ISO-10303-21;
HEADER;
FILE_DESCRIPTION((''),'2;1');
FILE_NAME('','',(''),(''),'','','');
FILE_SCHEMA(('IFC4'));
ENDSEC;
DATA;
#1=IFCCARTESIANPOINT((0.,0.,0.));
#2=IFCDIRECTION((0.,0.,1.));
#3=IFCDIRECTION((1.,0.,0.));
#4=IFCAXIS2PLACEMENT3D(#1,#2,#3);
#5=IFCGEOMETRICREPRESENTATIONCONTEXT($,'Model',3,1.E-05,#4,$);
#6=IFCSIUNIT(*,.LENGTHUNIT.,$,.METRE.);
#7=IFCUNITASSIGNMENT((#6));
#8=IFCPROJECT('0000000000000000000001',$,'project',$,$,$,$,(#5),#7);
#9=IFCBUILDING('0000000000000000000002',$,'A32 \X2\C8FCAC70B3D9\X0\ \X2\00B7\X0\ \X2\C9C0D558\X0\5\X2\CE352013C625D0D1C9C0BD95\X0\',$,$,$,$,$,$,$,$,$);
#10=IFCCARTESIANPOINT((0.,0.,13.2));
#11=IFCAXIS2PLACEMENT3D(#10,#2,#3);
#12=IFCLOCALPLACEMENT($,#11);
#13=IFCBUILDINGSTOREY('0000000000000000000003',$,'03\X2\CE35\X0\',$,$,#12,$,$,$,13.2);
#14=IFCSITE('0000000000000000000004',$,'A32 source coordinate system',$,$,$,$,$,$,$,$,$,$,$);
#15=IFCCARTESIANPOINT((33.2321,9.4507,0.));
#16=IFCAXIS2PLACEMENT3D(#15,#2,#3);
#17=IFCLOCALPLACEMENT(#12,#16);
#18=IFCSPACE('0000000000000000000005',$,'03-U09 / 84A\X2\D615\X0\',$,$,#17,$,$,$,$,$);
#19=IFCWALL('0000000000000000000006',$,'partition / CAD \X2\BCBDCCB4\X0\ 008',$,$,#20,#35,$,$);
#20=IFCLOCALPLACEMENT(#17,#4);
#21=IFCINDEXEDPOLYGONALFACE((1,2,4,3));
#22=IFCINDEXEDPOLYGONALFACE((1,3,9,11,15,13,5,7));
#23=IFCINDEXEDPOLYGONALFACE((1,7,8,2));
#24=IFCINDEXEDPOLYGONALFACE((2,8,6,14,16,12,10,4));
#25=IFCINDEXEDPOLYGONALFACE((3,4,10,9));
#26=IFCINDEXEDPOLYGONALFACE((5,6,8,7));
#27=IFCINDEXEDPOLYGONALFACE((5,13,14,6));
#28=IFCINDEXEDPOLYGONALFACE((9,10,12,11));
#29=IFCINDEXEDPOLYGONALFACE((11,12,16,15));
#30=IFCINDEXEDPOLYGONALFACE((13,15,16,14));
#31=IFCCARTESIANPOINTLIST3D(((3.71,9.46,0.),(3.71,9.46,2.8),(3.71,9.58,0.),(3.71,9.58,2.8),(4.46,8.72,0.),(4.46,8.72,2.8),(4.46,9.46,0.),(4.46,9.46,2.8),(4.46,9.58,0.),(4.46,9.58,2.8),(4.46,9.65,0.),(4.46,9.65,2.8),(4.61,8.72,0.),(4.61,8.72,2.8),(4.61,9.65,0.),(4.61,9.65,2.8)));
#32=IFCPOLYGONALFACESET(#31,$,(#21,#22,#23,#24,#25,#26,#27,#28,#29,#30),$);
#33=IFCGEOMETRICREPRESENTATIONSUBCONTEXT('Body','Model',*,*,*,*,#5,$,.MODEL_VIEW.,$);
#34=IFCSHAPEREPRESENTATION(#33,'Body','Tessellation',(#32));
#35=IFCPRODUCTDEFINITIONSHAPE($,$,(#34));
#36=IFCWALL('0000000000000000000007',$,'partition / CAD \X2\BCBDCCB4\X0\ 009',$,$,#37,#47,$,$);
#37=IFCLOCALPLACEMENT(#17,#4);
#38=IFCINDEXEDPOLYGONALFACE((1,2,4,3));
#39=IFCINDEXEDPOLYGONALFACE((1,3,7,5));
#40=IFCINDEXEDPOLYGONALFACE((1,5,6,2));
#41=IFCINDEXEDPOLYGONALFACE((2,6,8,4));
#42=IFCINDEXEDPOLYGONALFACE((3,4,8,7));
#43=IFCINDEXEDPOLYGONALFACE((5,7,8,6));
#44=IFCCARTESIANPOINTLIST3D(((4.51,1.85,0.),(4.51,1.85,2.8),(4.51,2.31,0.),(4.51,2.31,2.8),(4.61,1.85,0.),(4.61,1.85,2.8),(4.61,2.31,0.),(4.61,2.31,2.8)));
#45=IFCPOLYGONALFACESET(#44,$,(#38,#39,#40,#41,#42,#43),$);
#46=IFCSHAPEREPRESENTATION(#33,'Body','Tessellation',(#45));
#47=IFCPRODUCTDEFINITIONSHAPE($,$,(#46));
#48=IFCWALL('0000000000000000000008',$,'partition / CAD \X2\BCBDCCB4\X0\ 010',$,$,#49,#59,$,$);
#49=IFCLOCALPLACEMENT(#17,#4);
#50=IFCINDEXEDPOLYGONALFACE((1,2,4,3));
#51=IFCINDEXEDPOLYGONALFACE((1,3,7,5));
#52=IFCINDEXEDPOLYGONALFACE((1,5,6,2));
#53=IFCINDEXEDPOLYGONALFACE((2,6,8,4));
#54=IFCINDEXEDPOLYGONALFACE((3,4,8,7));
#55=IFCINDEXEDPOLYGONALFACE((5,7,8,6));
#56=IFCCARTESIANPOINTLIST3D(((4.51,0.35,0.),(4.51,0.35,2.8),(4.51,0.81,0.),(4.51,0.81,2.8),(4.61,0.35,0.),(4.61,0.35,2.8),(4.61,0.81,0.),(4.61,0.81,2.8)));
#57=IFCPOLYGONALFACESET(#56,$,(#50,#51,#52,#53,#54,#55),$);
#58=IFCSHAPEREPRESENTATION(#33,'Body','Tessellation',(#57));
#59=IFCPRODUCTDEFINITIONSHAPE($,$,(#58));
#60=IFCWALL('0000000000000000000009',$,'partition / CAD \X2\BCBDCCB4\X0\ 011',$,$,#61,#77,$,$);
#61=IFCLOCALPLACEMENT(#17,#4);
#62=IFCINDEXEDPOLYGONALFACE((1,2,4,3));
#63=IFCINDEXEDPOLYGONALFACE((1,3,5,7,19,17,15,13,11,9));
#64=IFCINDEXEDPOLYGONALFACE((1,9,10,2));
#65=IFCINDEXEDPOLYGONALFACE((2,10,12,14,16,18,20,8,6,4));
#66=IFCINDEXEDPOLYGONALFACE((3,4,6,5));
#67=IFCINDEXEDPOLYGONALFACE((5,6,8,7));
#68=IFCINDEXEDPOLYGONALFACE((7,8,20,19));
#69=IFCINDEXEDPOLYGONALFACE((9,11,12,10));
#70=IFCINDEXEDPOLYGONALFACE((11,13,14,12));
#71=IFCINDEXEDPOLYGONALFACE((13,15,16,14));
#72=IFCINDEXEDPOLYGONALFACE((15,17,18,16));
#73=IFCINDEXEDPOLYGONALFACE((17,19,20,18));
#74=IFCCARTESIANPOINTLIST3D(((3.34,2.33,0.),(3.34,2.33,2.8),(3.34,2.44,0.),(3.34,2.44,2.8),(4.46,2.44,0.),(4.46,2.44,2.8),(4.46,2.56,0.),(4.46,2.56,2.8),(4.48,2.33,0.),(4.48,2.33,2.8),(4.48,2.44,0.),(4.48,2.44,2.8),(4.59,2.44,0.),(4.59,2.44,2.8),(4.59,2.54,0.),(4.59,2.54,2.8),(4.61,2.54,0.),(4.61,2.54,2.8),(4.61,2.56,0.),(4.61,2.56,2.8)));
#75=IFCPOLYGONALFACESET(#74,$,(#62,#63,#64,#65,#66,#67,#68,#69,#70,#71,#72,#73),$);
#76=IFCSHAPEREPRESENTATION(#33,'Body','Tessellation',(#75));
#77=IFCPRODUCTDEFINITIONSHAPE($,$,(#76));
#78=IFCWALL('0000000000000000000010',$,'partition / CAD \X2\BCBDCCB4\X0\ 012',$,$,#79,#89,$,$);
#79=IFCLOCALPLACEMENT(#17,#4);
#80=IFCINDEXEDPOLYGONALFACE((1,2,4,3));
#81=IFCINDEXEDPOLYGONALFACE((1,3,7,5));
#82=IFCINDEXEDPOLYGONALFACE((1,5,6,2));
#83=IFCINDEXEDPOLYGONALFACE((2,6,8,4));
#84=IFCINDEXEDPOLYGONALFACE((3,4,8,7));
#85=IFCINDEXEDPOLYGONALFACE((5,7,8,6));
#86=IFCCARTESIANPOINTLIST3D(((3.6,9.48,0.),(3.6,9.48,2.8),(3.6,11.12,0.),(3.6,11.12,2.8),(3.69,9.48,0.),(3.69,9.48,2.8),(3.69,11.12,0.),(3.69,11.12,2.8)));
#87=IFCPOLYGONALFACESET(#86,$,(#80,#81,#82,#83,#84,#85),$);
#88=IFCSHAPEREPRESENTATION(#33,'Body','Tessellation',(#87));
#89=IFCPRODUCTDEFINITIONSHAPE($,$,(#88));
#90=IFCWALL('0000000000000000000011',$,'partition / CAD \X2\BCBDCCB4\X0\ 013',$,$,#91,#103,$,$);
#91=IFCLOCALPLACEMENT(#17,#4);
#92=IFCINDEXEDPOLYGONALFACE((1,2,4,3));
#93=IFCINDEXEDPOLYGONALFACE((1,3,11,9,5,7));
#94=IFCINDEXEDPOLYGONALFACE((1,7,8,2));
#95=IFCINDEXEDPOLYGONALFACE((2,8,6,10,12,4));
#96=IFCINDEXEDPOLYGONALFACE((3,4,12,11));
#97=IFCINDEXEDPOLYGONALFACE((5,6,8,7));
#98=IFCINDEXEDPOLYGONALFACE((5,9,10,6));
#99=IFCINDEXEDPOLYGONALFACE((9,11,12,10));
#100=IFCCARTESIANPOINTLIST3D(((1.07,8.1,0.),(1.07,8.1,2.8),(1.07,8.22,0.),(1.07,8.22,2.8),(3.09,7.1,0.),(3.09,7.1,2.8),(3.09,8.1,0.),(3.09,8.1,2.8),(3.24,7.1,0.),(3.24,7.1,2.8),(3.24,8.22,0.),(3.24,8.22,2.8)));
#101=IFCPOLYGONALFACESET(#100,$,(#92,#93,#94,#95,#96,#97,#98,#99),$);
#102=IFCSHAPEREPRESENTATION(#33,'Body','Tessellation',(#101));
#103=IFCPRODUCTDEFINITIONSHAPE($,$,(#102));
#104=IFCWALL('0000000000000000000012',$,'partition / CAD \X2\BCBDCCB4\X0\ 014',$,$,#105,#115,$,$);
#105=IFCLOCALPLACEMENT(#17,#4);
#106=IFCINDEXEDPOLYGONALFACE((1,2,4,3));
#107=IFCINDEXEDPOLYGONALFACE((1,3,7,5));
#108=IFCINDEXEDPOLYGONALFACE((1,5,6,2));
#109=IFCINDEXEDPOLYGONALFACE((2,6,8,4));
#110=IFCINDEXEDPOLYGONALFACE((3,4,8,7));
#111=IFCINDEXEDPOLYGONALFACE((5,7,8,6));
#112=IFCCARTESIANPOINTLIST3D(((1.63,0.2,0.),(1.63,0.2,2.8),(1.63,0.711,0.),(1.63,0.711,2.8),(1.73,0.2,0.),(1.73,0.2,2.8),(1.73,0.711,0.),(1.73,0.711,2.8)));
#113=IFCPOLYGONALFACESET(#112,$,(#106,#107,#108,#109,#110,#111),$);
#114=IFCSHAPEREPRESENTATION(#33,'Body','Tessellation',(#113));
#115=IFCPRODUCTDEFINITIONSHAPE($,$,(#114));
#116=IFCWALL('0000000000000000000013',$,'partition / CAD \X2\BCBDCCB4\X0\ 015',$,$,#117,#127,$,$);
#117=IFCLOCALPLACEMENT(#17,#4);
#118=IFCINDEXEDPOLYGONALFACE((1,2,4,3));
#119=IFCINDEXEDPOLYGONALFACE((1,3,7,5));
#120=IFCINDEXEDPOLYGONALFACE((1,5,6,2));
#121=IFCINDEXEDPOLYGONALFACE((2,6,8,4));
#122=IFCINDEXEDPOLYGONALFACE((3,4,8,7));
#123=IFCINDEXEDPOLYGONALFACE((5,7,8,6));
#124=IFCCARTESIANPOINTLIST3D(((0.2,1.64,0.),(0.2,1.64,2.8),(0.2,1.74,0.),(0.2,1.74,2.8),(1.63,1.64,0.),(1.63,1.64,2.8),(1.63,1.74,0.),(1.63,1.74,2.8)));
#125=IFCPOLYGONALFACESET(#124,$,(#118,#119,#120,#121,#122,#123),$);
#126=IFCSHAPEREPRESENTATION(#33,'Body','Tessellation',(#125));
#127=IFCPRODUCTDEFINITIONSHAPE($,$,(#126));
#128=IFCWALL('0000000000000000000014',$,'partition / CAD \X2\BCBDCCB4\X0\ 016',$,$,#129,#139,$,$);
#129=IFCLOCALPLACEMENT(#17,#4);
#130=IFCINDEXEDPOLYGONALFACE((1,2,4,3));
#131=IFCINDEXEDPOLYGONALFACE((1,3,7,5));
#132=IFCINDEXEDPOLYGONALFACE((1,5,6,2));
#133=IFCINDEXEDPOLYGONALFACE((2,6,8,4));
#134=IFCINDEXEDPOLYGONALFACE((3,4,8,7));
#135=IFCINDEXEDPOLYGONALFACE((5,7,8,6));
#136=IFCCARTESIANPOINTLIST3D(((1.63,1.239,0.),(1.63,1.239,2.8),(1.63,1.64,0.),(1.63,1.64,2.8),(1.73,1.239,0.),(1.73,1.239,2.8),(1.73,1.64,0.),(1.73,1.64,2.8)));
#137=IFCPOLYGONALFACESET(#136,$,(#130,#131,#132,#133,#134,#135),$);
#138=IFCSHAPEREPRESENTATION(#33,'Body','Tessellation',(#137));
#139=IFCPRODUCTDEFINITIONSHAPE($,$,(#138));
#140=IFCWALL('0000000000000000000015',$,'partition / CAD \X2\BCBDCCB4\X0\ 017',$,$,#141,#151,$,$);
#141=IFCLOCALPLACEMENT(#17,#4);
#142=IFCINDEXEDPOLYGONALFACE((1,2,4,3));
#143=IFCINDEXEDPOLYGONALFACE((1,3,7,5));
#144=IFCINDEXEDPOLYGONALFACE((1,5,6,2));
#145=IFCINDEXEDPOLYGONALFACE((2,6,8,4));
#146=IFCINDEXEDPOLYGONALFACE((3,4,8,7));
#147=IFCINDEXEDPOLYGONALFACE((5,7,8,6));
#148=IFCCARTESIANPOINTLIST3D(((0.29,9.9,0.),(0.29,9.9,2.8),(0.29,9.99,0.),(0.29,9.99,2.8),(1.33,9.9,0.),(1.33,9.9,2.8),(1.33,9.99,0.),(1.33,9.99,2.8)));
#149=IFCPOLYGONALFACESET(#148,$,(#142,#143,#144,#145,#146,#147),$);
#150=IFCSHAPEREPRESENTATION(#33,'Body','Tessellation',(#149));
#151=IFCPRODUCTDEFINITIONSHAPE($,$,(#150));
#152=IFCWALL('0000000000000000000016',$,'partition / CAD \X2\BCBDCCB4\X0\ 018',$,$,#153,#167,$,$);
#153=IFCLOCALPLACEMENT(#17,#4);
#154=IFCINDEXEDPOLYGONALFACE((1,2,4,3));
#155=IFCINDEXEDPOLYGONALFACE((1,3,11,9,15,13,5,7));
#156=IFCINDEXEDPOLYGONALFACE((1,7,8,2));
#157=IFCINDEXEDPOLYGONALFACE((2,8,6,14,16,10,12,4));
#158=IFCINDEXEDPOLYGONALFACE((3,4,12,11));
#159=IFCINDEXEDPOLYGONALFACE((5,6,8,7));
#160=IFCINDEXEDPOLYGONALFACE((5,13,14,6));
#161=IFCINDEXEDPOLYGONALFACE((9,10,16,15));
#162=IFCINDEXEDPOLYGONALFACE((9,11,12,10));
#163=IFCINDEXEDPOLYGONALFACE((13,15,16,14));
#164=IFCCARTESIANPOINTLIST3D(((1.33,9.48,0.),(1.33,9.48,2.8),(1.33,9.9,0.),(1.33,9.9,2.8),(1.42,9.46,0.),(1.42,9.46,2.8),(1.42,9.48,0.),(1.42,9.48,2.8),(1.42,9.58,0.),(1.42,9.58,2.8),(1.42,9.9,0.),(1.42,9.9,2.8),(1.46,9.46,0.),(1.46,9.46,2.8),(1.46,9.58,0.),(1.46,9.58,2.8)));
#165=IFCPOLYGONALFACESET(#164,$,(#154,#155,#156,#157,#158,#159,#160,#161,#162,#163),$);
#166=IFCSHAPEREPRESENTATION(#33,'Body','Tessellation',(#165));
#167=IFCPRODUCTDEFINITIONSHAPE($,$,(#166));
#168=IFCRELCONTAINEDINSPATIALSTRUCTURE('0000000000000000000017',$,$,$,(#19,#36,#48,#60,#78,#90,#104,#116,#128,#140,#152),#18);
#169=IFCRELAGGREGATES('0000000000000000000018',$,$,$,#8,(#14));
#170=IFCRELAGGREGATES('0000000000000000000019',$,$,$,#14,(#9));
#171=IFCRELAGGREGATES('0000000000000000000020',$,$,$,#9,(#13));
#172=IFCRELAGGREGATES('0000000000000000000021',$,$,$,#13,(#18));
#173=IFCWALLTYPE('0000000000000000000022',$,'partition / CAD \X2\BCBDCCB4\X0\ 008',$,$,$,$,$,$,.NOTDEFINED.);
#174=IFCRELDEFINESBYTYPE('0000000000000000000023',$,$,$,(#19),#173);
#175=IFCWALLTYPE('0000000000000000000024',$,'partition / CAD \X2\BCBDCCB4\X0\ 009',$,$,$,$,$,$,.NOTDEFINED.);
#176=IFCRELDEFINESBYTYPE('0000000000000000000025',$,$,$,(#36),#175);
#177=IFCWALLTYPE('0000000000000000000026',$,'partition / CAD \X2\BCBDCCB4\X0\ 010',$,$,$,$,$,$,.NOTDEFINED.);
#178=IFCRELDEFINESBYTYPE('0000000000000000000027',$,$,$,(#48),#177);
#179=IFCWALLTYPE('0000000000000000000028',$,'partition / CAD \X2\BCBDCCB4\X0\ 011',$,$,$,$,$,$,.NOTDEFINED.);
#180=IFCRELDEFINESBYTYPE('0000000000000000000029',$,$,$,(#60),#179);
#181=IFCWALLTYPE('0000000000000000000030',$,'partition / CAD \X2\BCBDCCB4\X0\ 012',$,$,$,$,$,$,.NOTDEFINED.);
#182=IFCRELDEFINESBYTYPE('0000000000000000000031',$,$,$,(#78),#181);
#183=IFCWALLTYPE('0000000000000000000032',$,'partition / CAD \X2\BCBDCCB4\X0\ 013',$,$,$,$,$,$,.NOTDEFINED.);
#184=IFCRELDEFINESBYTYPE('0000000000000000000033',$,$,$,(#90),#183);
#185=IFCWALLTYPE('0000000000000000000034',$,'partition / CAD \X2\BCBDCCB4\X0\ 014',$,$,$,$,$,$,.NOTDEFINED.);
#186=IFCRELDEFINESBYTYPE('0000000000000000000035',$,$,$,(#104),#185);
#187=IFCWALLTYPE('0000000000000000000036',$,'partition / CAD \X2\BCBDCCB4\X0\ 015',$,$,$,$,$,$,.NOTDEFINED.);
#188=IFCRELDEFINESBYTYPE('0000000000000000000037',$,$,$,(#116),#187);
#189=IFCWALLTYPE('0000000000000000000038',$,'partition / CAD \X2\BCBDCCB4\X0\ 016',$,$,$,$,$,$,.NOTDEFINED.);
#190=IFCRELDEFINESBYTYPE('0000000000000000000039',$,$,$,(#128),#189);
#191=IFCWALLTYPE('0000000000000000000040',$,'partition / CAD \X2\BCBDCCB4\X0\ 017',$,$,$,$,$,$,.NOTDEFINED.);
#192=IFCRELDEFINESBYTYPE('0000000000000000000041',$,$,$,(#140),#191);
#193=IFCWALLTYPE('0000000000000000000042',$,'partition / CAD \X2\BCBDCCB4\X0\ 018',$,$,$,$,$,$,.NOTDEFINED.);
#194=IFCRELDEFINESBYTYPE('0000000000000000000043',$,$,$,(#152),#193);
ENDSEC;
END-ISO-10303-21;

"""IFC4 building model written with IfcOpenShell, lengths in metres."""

from ifc_helpers import new_model, si_unit, frame, origin, origin_with_axes, place, context, subcontext, project, spatial, polyline, outline, extrude, source, transform, mapped, type_object, type_shapes, element, save


model = new_model("IFC4")

# Units and contexts
model_context = context("Model", 3, precision=1e-05, world=origin_with_axes())
body_context = subcontext(model_context, "Body", "Model", "MODEL_VIEW")
ifc_project = project(units=[si_unit("LENGTHUNIT", "METRE")], contexts=[model_context])

# Site, building, storey, space
site = spatial("IfcSite", under=ifc_project, Name="A32 source coordinate system")
building = spatial("IfcBuilding", under=site, Name="A32 주거동 · 지하5층–옥탑지붕")
storey_placement = place(None, frame((0.0, 0.0, 13.2), z_axis=(0.0, 0.0, 1.0), x_axis=(1.0, 0.0, 0.0)))
storey = spatial("IfcBuildingStorey", under=building, at=storey_placement, Name="03층", Elevation=13.2)
space_placement = place(storey_placement, frame((33.2321, 9.4507, 0.0), z_axis=(0.0, 0.0, 1.0), x_axis=(1.0, 0.0, 0.0)))
space = spatial("IfcSpace", under=storey, at=space_placement, Name="03-U09 / 84A형")

# Walls
wall_type_1 = type_object("IfcWallType", Name="partition / CAD 벽체 008", PredefinedType="NOTDEFINED")
shared_shape_1 = source(origin(), body_context, "Body", "SweptSolid", [
    extrude(outline(polyline([(4.61, 8.72), (4.46, 8.72), (4.46, 9.46), (3.71, 9.46), (3.71, 9.58), (4.46, 9.58), (4.46, 9.65), (4.61, 9.65), (4.61, 8.72)])), origin(), (0.0, 0.0, 1.0), 2.8),
])
type_shapes(wall_type_1, [shared_shape_1])
wall_1_placement = place(space_placement, origin_with_axes())
element("IfcWall", 1, at=wall_1_placement, inside=space, type_object=wall_type_1, Name="partition / CAD 벽체 008", context=body_context, shape_type="MappedRepresentation", body=[
    mapped(shared_shape_1, transform((0.0, 0.0, 0.0), scale=1.0)),
])
wall_type_2 = type_object("IfcWallType", Name="partition / CAD 벽체 009", PredefinedType="NOTDEFINED")
shared_shape_2 = source(origin(), body_context, "Body", "SweptSolid", [
    extrude(outline(polyline([(4.51, 1.85), (4.51, 2.31), (4.61, 2.31), (4.61, 1.85), (4.51, 1.85)])), origin(), (0.0, 0.0, 1.0), 2.8),
])
type_shapes(wall_type_2, [shared_shape_2])
wall_2_placement = place(space_placement, origin_with_axes())
element("IfcWall", 2, at=wall_2_placement, inside=space, type_object=wall_type_2, Name="partition / CAD 벽체 009", context=body_context, shape_type="MappedRepresentation", body=[
    mapped(shared_shape_2, transform((0.0, 0.0, 0.0), scale=1.0)),
])
wall_type_3 = type_object("IfcWallType", Name="partition / CAD 벽체 010", PredefinedType="NOTDEFINED")
shared_shape_3 = source(origin(), body_context, "Body", "SweptSolid", [
    extrude(outline(polyline([(4.51, 0.81), (4.61, 0.81), (4.61, 0.35), (4.51, 0.35), (4.51, 0.81)])), origin(), (0.0, 0.0, 1.0), 2.8),
])
type_shapes(wall_type_3, [shared_shape_3])
wall_3_placement = place(space_placement, origin_with_axes())
element("IfcWall", 3, at=wall_3_placement, inside=space, type_object=wall_type_3, Name="partition / CAD 벽체 010", context=body_context, shape_type="MappedRepresentation", body=[
    mapped(shared_shape_3, transform((0.0, 0.0, 0.0), scale=1.0)),
])
wall_type_4 = type_object("IfcWallType", Name="partition / CAD 벽체 011", PredefinedType="NOTDEFINED")
shared_shape_4 = source(origin(), body_context, "Body", "SweptSolid", [
    extrude(outline(polyline([(3.34, 2.33), (3.34, 2.44), (4.46, 2.44), (4.46, 2.56), (4.61, 2.56), (4.61, 2.54), (4.59, 2.54), (4.59, 2.44), (4.48, 2.44), (4.48, 2.33), (3.34, 2.33)])), origin(), (0.0, 0.0, 1.0), 2.8),
])
type_shapes(wall_type_4, [shared_shape_4])
wall_4_placement = place(space_placement, origin_with_axes())
element("IfcWall", 4, at=wall_4_placement, inside=space, type_object=wall_type_4, Name="partition / CAD 벽체 011", context=body_context, shape_type="MappedRepresentation", body=[
    mapped(shared_shape_4, transform((0.0, 0.0, 0.0), scale=1.0)),
])
wall_type_5 = type_object("IfcWallType", Name="partition / CAD 벽체 012", PredefinedType="NOTDEFINED")
shared_shape_5 = source(origin(), body_context, "Body", "SweptSolid", [
    extrude(outline(polyline([(3.6, 11.12), (3.69, 11.12), (3.69, 9.48), (3.6, 9.48), (3.6, 11.12)])), origin(), (0.0, 0.0, 1.0), 2.8),
])
type_shapes(wall_type_5, [shared_shape_5])
wall_5_placement = place(space_placement, origin_with_axes())
element("IfcWall", 5, at=wall_5_placement, inside=space, type_object=wall_type_5, Name="partition / CAD 벽체 012", context=body_context, shape_type="MappedRepresentation", body=[
    mapped(shared_shape_5, transform((0.0, 0.0, 0.0), scale=1.0)),
])
wall_type_6 = type_object("IfcWallType", Name="partition / CAD 벽체 013", PredefinedType="NOTDEFINED")
shared_shape_6 = source(origin(), body_context, "Body", "SweptSolid", [
    extrude(outline(polyline([(3.09, 8.1), (1.07, 8.1), (1.07, 8.22), (3.24, 8.22), (3.24, 7.1), (3.09, 7.1), (3.09, 8.1)])), origin(), (0.0, 0.0, 1.0), 2.8),
])
type_shapes(wall_type_6, [shared_shape_6])
wall_6_placement = place(space_placement, origin_with_axes())
element("IfcWall", 6, at=wall_6_placement, inside=space, type_object=wall_type_6, Name="partition / CAD 벽체 013", context=body_context, shape_type="MappedRepresentation", body=[
    mapped(shared_shape_6, transform((0.0, 0.0, 0.0), scale=1.0)),
])
wall_type_7 = type_object("IfcWallType", Name="partition / CAD 벽체 014", PredefinedType="NOTDEFINED")
shared_shape_7 = source(origin(), body_context, "Body", "SweptSolid", [
    extrude(outline(polyline([(1.73, 0.2), (1.63, 0.2), (1.63, 0.711), (1.73, 0.711), (1.73, 0.2)])), origin(), (0.0, 0.0, 1.0), 2.8),
])
type_shapes(wall_type_7, [shared_shape_7])
wall_7_placement = place(space_placement, origin_with_axes())
element("IfcWall", 7, at=wall_7_placement, inside=space, type_object=wall_type_7, Name="partition / CAD 벽체 014", context=body_context, shape_type="MappedRepresentation", body=[
    mapped(shared_shape_7, transform((0.0, 0.0, 0.0), scale=1.0)),
])
wall_type_8 = type_object("IfcWallType", Name="partition / CAD 벽체 015", PredefinedType="NOTDEFINED")
shared_shape_8 = source(origin(), body_context, "Body", "SweptSolid", [
    extrude(outline(polyline([(1.63, 1.74), (1.63, 1.64), (0.2, 1.64), (0.2, 1.74), (1.63, 1.74)])), origin(), (0.0, 0.0, 1.0), 2.8),
])
type_shapes(wall_type_8, [shared_shape_8])
wall_8_placement = place(space_placement, origin_with_axes())
element("IfcWall", 8, at=wall_8_placement, inside=space, type_object=wall_type_8, Name="partition / CAD 벽체 015", context=body_context, shape_type="MappedRepresentation", body=[
    mapped(shared_shape_8, transform((0.0, 0.0, 0.0), scale=1.0)),
])
wall_type_9 = type_object("IfcWallType", Name="partition / CAD 벽체 016", PredefinedType="NOTDEFINED")
shared_shape_9 = source(origin(), body_context, "Body", "SweptSolid", [
    extrude(outline(polyline([(1.73, 1.239), (1.63, 1.239), (1.63, 1.64), (1.73, 1.64), (1.73, 1.239)])), origin(), (0.0, 0.0, 1.0), 2.8),
])
type_shapes(wall_type_9, [shared_shape_9])
wall_9_placement = place(space_placement, origin_with_axes())
element("IfcWall", 9, at=wall_9_placement, inside=space, type_object=wall_type_9, Name="partition / CAD 벽체 016", context=body_context, shape_type="MappedRepresentation", body=[
    mapped(shared_shape_9, transform((0.0, 0.0, 0.0), scale=1.0)),
])
wall_type_10 = type_object("IfcWallType", Name="partition / CAD 벽체 017", PredefinedType="NOTDEFINED")
shared_shape_10 = source(origin(), body_context, "Body", "SweptSolid", [
    extrude(outline(polyline([(1.33, 9.99), (1.33, 9.9), (0.29, 9.9), (0.29, 9.99), (1.33, 9.99)])), origin(), (0.0, 0.0, 1.0), 2.8),
])
type_shapes(wall_type_10, [shared_shape_10])
wall_10_placement = place(space_placement, origin_with_axes())
element("IfcWall", 10, at=wall_10_placement, inside=space, type_object=wall_type_10, Name="partition / CAD 벽체 017", context=body_context, shape_type="MappedRepresentation", body=[
    mapped(shared_shape_10, transform((0.0, 0.0, 0.0), scale=1.0)),
])
wall_type_11 = type_object("IfcWallType", Name="partition / CAD 벽체 018", PredefinedType="NOTDEFINED")
shared_shape_11 = source(origin(), body_context, "Body", "SweptSolid", [
    extrude(outline(polyline([(1.42, 9.58), (1.46, 9.58), (1.46, 9.46), (1.42, 9.46), (1.42, 9.48), (1.33, 9.48), (1.33, 9.9), (1.42, 9.9), (1.42, 9.58)])), origin(), (0.0, 0.0, 1.0), 2.8),
])
type_shapes(wall_type_11, [shared_shape_11])
wall_11_placement = place(space_placement, origin_with_axes())
element("IfcWall", 11, at=wall_11_placement, inside=space, type_object=wall_type_11, Name="partition / CAD 벽체 018", context=body_context, shape_type="MappedRepresentation", body=[
    mapped(shared_shape_11, transform((0.0, 0.0, 0.0), scale=1.0)),
])

save(model, "model.ifc")
